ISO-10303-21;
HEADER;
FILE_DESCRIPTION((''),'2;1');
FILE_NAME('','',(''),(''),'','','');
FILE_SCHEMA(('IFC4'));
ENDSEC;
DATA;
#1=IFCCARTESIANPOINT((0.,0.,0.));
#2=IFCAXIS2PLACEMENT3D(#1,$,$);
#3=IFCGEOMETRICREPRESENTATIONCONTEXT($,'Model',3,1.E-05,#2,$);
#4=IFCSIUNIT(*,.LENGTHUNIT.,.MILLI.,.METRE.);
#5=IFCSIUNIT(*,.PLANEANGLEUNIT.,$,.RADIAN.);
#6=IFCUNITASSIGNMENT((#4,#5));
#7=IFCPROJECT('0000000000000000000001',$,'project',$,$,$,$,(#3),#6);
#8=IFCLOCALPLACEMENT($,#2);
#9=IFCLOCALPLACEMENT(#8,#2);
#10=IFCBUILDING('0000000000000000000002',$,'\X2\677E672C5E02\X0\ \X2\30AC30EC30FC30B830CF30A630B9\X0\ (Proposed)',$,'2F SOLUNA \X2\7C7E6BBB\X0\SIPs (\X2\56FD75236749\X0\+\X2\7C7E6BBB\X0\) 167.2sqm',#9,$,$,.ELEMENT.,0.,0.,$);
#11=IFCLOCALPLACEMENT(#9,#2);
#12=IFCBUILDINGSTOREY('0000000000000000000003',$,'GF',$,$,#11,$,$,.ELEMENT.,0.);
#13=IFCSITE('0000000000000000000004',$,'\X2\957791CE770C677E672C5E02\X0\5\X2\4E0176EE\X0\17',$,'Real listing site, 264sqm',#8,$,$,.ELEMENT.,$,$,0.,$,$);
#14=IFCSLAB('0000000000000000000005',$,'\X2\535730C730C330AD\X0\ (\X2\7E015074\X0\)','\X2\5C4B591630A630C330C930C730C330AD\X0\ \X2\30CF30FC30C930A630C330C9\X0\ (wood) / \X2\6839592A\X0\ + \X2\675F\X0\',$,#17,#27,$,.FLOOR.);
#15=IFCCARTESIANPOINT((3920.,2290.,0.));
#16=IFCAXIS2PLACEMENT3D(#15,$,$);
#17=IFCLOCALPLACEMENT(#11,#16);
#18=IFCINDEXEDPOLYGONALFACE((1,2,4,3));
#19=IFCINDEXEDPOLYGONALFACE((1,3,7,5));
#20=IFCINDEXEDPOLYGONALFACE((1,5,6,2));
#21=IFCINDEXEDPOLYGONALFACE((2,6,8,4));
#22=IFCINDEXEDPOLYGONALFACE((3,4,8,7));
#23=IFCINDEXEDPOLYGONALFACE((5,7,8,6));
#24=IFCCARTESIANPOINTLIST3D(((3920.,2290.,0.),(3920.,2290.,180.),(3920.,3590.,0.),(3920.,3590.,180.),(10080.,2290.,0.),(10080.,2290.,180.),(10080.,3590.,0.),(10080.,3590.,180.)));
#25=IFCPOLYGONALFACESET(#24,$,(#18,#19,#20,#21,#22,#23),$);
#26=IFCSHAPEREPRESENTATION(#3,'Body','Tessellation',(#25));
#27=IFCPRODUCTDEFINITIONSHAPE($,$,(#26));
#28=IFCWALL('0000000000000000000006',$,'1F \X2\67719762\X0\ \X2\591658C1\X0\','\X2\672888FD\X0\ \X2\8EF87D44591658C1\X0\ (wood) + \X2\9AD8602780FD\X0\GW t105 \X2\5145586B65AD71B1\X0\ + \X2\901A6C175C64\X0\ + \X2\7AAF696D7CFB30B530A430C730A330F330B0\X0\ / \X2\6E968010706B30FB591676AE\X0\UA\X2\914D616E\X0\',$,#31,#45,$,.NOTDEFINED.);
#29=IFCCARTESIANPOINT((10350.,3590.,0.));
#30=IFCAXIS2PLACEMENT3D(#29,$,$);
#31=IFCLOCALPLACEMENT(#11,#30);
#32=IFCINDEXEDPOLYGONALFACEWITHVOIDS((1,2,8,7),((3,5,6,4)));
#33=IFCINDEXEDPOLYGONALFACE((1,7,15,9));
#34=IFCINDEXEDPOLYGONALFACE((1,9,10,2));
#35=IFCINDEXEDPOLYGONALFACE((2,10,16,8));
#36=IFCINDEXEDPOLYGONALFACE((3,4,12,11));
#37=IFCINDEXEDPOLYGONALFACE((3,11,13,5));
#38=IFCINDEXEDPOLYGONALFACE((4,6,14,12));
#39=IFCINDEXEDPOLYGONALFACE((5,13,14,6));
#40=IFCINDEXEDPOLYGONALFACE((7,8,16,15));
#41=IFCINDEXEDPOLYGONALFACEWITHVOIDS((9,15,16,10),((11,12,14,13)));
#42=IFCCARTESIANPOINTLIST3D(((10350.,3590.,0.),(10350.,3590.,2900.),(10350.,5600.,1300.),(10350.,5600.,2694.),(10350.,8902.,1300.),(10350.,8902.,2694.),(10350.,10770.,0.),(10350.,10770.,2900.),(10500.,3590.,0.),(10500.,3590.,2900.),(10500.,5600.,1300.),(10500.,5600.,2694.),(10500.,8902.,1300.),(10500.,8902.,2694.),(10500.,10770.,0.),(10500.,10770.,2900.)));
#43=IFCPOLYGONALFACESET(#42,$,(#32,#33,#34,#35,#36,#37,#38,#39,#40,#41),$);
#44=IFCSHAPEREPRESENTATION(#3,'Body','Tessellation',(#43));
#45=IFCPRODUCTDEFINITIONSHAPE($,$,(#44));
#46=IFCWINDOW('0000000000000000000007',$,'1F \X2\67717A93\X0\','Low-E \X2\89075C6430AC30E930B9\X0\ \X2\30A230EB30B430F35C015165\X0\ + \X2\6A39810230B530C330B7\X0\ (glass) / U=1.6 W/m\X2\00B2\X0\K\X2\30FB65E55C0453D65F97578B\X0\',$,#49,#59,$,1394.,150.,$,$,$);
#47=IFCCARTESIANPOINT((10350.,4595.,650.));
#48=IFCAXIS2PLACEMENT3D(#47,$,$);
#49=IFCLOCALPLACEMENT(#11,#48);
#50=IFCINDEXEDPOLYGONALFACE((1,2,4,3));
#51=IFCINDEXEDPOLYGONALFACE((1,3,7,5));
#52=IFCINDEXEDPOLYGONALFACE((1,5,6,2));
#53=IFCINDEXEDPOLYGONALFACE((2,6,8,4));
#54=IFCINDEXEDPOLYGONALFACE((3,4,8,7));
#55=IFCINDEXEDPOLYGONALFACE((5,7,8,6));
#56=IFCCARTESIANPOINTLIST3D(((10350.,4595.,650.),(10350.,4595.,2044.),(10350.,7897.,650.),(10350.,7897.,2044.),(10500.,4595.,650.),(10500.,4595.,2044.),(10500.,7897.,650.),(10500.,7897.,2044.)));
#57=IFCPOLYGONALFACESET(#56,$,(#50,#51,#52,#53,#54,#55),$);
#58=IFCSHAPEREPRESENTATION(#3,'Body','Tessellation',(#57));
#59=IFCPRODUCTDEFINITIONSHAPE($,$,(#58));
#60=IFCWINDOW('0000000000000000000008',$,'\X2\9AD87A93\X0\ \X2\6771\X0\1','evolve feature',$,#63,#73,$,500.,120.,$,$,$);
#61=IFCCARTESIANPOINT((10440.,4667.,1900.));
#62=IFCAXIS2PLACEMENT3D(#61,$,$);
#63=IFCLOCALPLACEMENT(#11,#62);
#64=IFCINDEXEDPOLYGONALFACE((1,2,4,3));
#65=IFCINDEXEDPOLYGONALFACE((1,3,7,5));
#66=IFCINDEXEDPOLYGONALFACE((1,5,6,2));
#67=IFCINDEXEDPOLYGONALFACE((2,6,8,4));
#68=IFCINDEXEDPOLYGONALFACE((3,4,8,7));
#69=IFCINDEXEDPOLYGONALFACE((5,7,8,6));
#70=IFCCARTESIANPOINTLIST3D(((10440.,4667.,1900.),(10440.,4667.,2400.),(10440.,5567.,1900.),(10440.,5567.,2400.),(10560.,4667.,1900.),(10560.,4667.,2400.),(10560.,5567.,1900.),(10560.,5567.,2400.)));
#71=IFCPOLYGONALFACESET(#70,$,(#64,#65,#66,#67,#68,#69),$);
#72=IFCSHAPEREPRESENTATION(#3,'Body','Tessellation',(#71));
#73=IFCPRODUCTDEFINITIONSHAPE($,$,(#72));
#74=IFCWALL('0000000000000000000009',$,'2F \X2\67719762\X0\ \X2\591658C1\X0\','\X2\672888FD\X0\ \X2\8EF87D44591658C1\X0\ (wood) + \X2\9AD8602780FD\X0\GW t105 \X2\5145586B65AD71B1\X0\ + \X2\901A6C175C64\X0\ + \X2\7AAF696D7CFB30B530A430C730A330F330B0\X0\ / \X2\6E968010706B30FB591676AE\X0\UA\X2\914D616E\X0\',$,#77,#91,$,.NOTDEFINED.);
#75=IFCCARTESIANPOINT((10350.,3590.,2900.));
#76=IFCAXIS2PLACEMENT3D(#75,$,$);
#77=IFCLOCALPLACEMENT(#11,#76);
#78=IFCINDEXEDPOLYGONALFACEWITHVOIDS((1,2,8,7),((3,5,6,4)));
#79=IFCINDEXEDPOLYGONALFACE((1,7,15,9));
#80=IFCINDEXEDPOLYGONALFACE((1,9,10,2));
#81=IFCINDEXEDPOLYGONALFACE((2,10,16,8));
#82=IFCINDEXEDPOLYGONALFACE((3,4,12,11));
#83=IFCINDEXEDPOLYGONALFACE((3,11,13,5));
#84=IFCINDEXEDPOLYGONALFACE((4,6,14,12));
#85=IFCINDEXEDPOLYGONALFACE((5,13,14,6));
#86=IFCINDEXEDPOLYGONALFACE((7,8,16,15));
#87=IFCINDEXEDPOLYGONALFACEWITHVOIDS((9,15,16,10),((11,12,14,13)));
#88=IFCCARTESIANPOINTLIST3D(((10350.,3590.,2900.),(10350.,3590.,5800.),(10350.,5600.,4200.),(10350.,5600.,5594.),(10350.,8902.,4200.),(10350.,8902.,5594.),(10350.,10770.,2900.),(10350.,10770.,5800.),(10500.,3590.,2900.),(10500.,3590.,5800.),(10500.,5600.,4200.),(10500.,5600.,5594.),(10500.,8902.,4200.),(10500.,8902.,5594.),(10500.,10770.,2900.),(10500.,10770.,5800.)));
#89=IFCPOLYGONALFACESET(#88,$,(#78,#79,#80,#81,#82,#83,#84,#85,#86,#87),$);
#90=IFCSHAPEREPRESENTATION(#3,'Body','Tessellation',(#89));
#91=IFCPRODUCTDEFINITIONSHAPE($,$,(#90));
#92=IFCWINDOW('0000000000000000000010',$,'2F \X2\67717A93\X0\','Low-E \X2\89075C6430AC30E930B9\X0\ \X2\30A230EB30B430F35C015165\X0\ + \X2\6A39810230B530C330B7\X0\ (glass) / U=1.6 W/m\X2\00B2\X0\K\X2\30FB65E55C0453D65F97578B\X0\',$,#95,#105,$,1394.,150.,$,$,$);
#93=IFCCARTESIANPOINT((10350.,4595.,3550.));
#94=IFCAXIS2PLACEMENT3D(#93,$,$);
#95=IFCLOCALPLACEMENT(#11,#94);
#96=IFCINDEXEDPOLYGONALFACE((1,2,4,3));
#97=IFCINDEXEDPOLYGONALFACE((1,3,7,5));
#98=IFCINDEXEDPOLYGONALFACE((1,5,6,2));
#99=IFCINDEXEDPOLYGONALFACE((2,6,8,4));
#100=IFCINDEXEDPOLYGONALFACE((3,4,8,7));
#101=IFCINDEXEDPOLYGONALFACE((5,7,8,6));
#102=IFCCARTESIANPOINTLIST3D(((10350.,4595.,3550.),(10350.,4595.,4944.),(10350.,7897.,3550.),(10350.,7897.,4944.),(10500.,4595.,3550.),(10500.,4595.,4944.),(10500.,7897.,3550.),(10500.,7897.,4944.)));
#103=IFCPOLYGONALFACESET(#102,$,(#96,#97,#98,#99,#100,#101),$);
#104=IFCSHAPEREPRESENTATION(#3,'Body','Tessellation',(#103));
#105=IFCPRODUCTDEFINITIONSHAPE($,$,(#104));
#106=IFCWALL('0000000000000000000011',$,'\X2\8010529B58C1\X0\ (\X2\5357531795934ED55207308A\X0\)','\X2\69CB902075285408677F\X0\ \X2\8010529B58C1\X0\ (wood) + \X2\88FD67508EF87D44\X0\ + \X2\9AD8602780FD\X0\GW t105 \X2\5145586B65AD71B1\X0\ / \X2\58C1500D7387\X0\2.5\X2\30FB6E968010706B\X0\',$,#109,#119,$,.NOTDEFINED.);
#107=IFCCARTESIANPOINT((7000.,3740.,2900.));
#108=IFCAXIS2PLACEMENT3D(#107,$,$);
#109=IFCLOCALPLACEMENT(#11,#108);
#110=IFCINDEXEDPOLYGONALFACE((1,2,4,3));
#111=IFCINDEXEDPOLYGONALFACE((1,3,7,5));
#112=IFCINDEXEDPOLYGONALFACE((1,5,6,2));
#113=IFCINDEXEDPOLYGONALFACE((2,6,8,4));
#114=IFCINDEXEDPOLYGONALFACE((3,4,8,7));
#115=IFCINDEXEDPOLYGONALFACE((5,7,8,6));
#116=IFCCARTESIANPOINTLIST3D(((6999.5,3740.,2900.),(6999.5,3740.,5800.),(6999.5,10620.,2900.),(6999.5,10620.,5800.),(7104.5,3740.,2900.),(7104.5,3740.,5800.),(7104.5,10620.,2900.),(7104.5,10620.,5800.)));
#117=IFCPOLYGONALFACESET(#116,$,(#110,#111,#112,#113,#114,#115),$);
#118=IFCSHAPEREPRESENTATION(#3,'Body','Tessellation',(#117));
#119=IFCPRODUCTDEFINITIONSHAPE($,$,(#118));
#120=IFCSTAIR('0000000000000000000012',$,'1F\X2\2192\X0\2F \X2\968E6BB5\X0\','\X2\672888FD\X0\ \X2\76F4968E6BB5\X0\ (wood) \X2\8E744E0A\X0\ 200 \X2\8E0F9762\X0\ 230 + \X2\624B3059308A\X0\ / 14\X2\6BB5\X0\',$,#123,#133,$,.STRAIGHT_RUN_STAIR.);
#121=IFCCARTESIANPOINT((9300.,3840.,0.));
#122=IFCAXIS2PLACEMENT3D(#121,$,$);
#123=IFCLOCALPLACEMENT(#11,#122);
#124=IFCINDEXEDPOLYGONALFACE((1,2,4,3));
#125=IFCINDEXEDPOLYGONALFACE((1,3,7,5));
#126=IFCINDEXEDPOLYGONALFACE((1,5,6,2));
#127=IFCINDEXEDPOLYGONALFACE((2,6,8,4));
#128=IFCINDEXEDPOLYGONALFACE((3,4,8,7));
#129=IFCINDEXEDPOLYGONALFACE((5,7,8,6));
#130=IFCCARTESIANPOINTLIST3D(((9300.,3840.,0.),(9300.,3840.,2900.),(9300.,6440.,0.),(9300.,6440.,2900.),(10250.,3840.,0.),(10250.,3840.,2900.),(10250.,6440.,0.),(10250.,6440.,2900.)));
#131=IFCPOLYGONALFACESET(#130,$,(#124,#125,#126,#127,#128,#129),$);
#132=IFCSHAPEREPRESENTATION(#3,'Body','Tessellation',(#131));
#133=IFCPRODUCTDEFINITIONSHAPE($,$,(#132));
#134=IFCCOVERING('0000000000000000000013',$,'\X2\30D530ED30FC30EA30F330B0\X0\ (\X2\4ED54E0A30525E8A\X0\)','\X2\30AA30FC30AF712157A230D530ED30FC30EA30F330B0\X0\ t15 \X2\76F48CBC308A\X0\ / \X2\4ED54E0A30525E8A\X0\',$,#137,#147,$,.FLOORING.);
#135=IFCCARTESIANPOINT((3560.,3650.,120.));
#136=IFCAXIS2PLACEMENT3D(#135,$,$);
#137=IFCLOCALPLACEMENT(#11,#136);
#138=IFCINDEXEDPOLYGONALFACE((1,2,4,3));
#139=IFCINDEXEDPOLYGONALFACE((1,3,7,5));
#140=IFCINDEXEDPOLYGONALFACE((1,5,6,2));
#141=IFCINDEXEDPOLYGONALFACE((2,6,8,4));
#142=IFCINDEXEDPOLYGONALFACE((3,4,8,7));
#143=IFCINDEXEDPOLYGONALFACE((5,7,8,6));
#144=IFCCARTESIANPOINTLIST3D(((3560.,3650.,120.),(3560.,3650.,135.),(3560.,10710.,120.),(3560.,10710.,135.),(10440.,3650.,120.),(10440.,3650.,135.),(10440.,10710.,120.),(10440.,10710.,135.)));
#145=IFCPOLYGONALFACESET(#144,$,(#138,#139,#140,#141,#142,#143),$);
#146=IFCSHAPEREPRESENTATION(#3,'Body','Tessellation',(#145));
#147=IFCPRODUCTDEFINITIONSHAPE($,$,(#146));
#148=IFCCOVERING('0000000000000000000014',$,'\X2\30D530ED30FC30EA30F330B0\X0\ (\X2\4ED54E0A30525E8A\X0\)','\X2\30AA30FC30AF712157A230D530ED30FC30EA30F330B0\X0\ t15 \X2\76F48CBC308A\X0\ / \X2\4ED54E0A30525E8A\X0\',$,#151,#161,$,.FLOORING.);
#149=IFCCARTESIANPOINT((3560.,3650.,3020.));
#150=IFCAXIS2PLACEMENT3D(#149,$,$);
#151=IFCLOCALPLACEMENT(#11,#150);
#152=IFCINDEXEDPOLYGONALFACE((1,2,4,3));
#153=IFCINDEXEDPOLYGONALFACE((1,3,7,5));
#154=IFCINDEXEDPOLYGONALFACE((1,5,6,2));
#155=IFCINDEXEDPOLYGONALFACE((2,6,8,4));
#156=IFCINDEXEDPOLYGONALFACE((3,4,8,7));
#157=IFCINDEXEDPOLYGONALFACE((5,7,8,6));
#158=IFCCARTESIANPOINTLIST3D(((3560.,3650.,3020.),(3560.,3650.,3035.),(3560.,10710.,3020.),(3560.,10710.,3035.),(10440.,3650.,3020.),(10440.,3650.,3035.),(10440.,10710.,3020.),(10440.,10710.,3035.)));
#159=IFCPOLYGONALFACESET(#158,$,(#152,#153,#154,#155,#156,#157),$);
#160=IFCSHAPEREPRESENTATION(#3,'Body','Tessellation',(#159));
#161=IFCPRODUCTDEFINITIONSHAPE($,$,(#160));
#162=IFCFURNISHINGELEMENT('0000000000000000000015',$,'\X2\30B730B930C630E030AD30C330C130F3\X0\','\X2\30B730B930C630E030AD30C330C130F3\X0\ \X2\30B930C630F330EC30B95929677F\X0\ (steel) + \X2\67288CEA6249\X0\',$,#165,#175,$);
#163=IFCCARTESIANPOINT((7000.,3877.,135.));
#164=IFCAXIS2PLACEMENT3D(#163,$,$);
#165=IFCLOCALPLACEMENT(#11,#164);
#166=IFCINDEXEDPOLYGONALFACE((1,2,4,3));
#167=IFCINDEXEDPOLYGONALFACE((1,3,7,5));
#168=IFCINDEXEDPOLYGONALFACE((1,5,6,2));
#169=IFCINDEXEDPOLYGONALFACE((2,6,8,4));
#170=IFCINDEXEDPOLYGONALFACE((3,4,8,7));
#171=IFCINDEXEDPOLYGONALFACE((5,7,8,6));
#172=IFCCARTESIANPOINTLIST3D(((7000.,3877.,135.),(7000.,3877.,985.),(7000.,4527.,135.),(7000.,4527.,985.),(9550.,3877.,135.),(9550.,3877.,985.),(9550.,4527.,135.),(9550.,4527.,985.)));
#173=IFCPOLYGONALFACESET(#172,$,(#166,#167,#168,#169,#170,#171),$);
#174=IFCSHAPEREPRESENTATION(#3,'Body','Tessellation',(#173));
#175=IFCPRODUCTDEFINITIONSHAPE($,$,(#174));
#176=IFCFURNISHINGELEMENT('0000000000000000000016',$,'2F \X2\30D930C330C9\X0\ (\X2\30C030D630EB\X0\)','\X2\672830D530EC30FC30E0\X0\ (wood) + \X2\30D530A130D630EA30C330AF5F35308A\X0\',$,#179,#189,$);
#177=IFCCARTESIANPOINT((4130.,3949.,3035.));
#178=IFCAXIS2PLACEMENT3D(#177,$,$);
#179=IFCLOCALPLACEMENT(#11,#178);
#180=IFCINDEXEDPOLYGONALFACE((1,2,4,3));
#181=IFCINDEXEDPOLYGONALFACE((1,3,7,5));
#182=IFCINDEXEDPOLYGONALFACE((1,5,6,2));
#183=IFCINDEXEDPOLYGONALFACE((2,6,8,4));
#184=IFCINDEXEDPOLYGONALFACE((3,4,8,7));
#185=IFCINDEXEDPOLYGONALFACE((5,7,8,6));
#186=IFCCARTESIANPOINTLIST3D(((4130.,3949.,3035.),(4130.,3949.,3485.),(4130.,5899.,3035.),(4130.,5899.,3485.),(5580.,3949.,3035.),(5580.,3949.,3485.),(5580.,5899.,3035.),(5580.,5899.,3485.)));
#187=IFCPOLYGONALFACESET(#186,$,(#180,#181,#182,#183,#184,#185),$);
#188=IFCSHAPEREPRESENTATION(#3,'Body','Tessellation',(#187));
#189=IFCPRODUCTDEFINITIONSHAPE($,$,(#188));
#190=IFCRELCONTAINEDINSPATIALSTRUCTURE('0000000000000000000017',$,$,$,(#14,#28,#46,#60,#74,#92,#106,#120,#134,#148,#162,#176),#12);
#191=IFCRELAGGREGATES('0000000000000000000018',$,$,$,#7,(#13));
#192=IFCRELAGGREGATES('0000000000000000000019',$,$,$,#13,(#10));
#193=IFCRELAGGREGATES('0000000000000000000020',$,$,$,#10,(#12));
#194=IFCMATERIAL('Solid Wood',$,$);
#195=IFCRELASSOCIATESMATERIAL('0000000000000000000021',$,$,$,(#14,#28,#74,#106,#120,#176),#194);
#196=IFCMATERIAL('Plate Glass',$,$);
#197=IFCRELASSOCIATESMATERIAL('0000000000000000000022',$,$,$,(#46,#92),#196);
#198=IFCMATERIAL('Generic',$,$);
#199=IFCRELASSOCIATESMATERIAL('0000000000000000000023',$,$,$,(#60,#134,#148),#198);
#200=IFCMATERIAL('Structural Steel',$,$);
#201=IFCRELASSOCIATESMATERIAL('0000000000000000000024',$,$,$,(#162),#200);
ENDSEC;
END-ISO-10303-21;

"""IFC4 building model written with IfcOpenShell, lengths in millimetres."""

from ifc_helpers import new_model, si_unit, frame, frame_2d, origin, place, context, project, spatial, rectangle, extrude, material, element, fill, save


model = new_model("IFC4")

# Units and contexts
model_context = context("Model", 3, precision=1e-05, world=origin())
ifc_project = project(units=[si_unit("LENGTHUNIT", "METRE", prefix="MILLI"), si_unit("PLANEANGLEUNIT", "RADIAN")], contexts=[model_context])

# Site, building, storey
site_placement = place(None, origin())
site = spatial("IfcSite", under=ifc_project, at=site_placement, Name="長野県松本市5丁目17", ObjectType="Real listing site, 264sqm", CompositionType="ELEMENT", RefElevation=0.0)
building_placement = place(site_placement, origin())
building = spatial("IfcBuilding", under=site, at=building_placement, Name="松本市 ガレージハウス (Proposed)", ObjectType="2F SOLUNA 籾殻SIPs (国産杉+籾殻) 167.2sqm", CompositionType="ELEMENT", ElevationOfRefHeight=0.0, ElevationOfTerrain=0.0)
storey_placement = place(building_placement, origin())
storey = spatial("IfcBuildingStorey", under=building, at=storey_placement, Name="GF", CompositionType="ELEMENT", Elevation=0.0)

# Slab
ifc_material_1 = material(Name="Solid Wood")
slab_placement = place(storey_placement, frame((3920.0, 2290.0, 0.0)))
element("IfcSlab", 1, at=slab_placement, inside=storey, material=ifc_material_1, Name="南デッキ (縁側)", Description="屋外ウッドデッキ ハードウッド (wood) / 根太 + 束", PredefinedType="FLOOR", context=model_context, shape_type="SweptSolid", body=[
    extrude(rectangle(XDim=6160.0, YDim=1300.0, at=frame_2d((3080.0, 650.0))), frame((3920.0, 2290.0, 0.0)), (0.0, 0.0, 1.0), 180.0),
])

# Wall, openings, windows
wall_1_placement = place(storey_placement, frame((10350.0, 3590.0, 0.0)))
wall_1 = element("IfcWall", 2, at=wall_1_placement, inside=storey, material=ifc_material_1, Name="1F 東面 外壁", Description="木製 軸組外壁 (wood) + 高性能GW t105 充填断熱 + 通気層 + 窯業系サイディング / 準耐火・外皮UA配慮", PredefinedType="NOTDEFINED", context=model_context, shape_type="SweptSolid", body=[
    extrude(rectangle(XDim=150.0, YDim=7180.0, at=frame_2d((75.0, 3590.0))), frame((10350.0, 3590.0, 0.0)), (0.0, 0.0, 1.0), 2900.0),
])
opening_1_placement = place(storey_placement, frame((10350.0, 4595.0, 650.0)))
opening_1 = element("IfcOpeningElement", 3, at=opening_1_placement, cuts=wall_1, PredefinedType="NOTDEFINED", context=model_context, shape_type="SweptSolid", body=[
    extrude(rectangle(XDim=150.0, YDim=3302.0, at=frame_2d((75.0, 1651.0))), frame((10350.0, 4595.0, 650.0)), (0.0, 0.0, 1.0), 1394.0),
])
opening_2_placement = place(storey_placement, frame((10440.0, 4667.0, 1900.0)))
opening_2 = element("IfcOpeningElement", 4, at=opening_2_placement, cuts=wall_1, PredefinedType="NOTDEFINED", context=model_context, shape_type="SweptSolid", body=[
    extrude(rectangle(XDim=120.0, YDim=900.0, at=frame_2d((60.0, 450.0))), frame((10440.0, 4667.0, 1900.0)), (0.0, 0.0, 1.0), 500.0),
])
ifc_material_2 = material(Name="Plate Glass")
window_1_placement = place(storey_placement, frame((10350.0, 4595.0, 650.0)))
window_1 = element("IfcWindow", 5, at=window_1_placement, inside=storey, material=ifc_material_2, Name="1F 東窓", Description="Low-E 複層ガラス アルゴン封入 + 樹脂サッシ (glass) / U=1.6 W/m²K・日射取得型", OverallHeight=1394.0, OverallWidth=150.0, context=model_context, shape_type="SweptSolid", body=[
    extrude(rectangle(XDim=150.0, YDim=3302.0, at=frame_2d((75.0, 1651.0))), frame((10350.0, 4595.0, 650.0)), (0.0, 0.0, 1.0), 1394.0),
])
fill(opening_1, window_1)
ifc_material_3 = material(Name="Generic")
window_2_placement = place(storey_placement, frame((10440.0, 4667.0, 1900.0)))
window_2 = element("IfcWindow", 6, at=window_2_placement, inside=storey, material=ifc_material_3, Name="高窓 東1", Description="evolve feature", OverallHeight=500.0, OverallWidth=120.0, context=model_context, shape_type="SweptSolid", body=[
    extrude(rectangle(XDim=120.0, YDim=900.0, at=frame_2d((60.0, 450.0))), frame((10440.0, 4667.0, 1900.0)), (0.0, 0.0, 1.0), 500.0),
])
fill(opening_2, window_2)

# Wall, opening, window
wall_2_placement = place(storey_placement, frame((10350.0, 3590.0, 2900.0)))
wall_2 = element("IfcWall", 7, at=wall_2_placement, inside=storey, material=ifc_material_1, Name="2F 東面 外壁", Description="木製 軸組外壁 (wood) + 高性能GW t105 充填断熱 + 通気層 + 窯業系サイディング / 準耐火・外皮UA配慮", PredefinedType="NOTDEFINED", context=model_context, shape_type="SweptSolid", body=[
    extrude(rectangle(XDim=150.0, YDim=7180.0, at=frame_2d((75.0, 3590.0))), frame((10350.0, 3590.0, 2900.0)), (0.0, 0.0, 1.0), 2900.0),
])
opening_3_placement = place(storey_placement, frame((10350.0, 4595.0, 3550.0)))
opening_3 = element("IfcOpeningElement", 8, at=opening_3_placement, cuts=wall_2, PredefinedType="NOTDEFINED", context=model_context, shape_type="SweptSolid", body=[
    extrude(rectangle(XDim=150.0, YDim=3302.0, at=frame_2d((75.0, 1651.0))), frame((10350.0, 4595.0, 3550.0)), (0.0, 0.0, 1.0), 1394.0),
])
window_3_placement = place(storey_placement, frame((10350.0, 4595.0, 3550.0)))
window_3 = element("IfcWindow", 9, at=window_3_placement, inside=storey, material=ifc_material_2, Name="2F 東窓", Description="Low-E 複層ガラス アルゴン封入 + 樹脂サッシ (glass) / U=1.6 W/m²K・日射取得型", OverallHeight=1394.0, OverallWidth=150.0, context=model_context, shape_type="SweptSolid", body=[
    extrude(rectangle(XDim=150.0, YDim=3302.0, at=frame_2d((75.0, 1651.0))), frame((10350.0, 4595.0, 3550.0)), (0.0, 0.0, 1.0), 1394.0),
])
fill(opening_3, window_3)

# Wall
wall_3_placement = place(storey_placement, frame((7000.0, 3740.0, 2900.0)))
element("IfcWall", 10, at=wall_3_placement, inside=storey, material=ifc_material_1, Name="耐力壁 (南北間仕切り)", Description="構造用合板 耐力壁 (wood) + 製材軸組 + 高性能GW t105 充填断熱 / 壁倍率2.5・準耐火", PredefinedType="NOTDEFINED", context=model_context, shape_type="SweptSolid", body=[
    extrude(rectangle(XDim=105.0, YDim=6880.0, at=frame_2d((52.0, 3440.0))), frame((7000.0, 3740.0, 2900.0)), (0.0, 0.0, 1.0), 2900.0),
])

# Stair
stair_placement = place(storey_placement, frame((9300.0, 3840.0, 0.0)))
element("IfcStair", 11, at=stair_placement, inside=storey, material=ifc_material_1, Name="1F→2F 階段", Description="木製 直階段 (wood) 蹴上 200 踏面 230 + 手すり / 14段", PredefinedType="STRAIGHT_RUN_STAIR", context=model_context, shape_type="SweptSolid", body=[
    extrude(rectangle(XDim=950.0, YDim=2600.0, at=frame_2d((475.0, 1300.0))), frame((9300.0, 3840.0, 0.0)), (0.0, 0.0, 1.0), 2900.0),
])

# Coverings
covering_1_placement = place(storey_placement, frame((3560.0, 3650.0, 120.0)))
element("IfcCovering", 12, at=covering_1_placement, inside=storey, material=ifc_material_3, Name="フローリング (仕上げ床)", Description="オーク無垢フローリング t15 直貼り / 仕上げ床", PredefinedType="FLOORING", context=model_context, shape_type="SweptSolid", body=[
    extrude(rectangle(XDim=6880.0, YDim=7060.0, at=frame_2d((3440.0, 3530.0))), frame((3560.0, 3650.0, 120.0)), (0.0, 0.0, 1.0), 15.0),
])
covering_2_placement = place(storey_placement, frame((3560.0, 3650.0, 3020.0)))
element("IfcCovering", 13, at=covering_2_placement, inside=storey, material=ifc_material_3, Name="フローリング (仕上げ床)", Description="オーク無垢フローリング t15 直貼り / 仕上げ床", PredefinedType="FLOORING", context=model_context, shape_type="SweptSolid", body=[
    extrude(rectangle(XDim=6880.0, YDim=7060.0, at=frame_2d((3440.0, 3530.0))), frame((3560.0, 3650.0, 3020.0)), (0.0, 0.0, 1.0), 15.0),
])

# Furnishing elements
ifc_material_4 = material(Name="Structural Steel")
furnishing_1_placement = place(storey_placement, frame((7000.0, 3877.0, 135.0)))
element("IfcFurnishingElement", 14, at=furnishing_1_placement, inside=storey, material=ifc_material_4, Name="システムキッチン", Description="システムキッチン ステンレス天板 (steel) + 木質扉", context=model_context, shape_type="SweptSolid", body=[
    extrude(rectangle(XDim=2550.0, YDim=650.0, at=frame_2d((1275.0, 325.0))), frame((7000.0, 3877.0, 135.0)), (0.0, 0.0, 1.0), 850.0),
])
furnishing_2_placement = place(storey_placement, frame((4130.0, 3949.0, 3035.0)))
element("IfcFurnishingElement", 15, at=furnishing_2_placement, inside=storey, material=ifc_material_1, Name="2F ベッド (ダブル)", Description="木フレーム (wood) + ファブリック張り", context=model_context, shape_type="SweptSolid", body=[
    extrude(rectangle(XDim=1450.0, YDim=1950.0, at=frame_2d((725.0, 975.0))), frame((4130.0, 3949.0, 3035.0)), (0.0, 0.0, 1.0), 450.0),
])

save(model, "model.ifc")
